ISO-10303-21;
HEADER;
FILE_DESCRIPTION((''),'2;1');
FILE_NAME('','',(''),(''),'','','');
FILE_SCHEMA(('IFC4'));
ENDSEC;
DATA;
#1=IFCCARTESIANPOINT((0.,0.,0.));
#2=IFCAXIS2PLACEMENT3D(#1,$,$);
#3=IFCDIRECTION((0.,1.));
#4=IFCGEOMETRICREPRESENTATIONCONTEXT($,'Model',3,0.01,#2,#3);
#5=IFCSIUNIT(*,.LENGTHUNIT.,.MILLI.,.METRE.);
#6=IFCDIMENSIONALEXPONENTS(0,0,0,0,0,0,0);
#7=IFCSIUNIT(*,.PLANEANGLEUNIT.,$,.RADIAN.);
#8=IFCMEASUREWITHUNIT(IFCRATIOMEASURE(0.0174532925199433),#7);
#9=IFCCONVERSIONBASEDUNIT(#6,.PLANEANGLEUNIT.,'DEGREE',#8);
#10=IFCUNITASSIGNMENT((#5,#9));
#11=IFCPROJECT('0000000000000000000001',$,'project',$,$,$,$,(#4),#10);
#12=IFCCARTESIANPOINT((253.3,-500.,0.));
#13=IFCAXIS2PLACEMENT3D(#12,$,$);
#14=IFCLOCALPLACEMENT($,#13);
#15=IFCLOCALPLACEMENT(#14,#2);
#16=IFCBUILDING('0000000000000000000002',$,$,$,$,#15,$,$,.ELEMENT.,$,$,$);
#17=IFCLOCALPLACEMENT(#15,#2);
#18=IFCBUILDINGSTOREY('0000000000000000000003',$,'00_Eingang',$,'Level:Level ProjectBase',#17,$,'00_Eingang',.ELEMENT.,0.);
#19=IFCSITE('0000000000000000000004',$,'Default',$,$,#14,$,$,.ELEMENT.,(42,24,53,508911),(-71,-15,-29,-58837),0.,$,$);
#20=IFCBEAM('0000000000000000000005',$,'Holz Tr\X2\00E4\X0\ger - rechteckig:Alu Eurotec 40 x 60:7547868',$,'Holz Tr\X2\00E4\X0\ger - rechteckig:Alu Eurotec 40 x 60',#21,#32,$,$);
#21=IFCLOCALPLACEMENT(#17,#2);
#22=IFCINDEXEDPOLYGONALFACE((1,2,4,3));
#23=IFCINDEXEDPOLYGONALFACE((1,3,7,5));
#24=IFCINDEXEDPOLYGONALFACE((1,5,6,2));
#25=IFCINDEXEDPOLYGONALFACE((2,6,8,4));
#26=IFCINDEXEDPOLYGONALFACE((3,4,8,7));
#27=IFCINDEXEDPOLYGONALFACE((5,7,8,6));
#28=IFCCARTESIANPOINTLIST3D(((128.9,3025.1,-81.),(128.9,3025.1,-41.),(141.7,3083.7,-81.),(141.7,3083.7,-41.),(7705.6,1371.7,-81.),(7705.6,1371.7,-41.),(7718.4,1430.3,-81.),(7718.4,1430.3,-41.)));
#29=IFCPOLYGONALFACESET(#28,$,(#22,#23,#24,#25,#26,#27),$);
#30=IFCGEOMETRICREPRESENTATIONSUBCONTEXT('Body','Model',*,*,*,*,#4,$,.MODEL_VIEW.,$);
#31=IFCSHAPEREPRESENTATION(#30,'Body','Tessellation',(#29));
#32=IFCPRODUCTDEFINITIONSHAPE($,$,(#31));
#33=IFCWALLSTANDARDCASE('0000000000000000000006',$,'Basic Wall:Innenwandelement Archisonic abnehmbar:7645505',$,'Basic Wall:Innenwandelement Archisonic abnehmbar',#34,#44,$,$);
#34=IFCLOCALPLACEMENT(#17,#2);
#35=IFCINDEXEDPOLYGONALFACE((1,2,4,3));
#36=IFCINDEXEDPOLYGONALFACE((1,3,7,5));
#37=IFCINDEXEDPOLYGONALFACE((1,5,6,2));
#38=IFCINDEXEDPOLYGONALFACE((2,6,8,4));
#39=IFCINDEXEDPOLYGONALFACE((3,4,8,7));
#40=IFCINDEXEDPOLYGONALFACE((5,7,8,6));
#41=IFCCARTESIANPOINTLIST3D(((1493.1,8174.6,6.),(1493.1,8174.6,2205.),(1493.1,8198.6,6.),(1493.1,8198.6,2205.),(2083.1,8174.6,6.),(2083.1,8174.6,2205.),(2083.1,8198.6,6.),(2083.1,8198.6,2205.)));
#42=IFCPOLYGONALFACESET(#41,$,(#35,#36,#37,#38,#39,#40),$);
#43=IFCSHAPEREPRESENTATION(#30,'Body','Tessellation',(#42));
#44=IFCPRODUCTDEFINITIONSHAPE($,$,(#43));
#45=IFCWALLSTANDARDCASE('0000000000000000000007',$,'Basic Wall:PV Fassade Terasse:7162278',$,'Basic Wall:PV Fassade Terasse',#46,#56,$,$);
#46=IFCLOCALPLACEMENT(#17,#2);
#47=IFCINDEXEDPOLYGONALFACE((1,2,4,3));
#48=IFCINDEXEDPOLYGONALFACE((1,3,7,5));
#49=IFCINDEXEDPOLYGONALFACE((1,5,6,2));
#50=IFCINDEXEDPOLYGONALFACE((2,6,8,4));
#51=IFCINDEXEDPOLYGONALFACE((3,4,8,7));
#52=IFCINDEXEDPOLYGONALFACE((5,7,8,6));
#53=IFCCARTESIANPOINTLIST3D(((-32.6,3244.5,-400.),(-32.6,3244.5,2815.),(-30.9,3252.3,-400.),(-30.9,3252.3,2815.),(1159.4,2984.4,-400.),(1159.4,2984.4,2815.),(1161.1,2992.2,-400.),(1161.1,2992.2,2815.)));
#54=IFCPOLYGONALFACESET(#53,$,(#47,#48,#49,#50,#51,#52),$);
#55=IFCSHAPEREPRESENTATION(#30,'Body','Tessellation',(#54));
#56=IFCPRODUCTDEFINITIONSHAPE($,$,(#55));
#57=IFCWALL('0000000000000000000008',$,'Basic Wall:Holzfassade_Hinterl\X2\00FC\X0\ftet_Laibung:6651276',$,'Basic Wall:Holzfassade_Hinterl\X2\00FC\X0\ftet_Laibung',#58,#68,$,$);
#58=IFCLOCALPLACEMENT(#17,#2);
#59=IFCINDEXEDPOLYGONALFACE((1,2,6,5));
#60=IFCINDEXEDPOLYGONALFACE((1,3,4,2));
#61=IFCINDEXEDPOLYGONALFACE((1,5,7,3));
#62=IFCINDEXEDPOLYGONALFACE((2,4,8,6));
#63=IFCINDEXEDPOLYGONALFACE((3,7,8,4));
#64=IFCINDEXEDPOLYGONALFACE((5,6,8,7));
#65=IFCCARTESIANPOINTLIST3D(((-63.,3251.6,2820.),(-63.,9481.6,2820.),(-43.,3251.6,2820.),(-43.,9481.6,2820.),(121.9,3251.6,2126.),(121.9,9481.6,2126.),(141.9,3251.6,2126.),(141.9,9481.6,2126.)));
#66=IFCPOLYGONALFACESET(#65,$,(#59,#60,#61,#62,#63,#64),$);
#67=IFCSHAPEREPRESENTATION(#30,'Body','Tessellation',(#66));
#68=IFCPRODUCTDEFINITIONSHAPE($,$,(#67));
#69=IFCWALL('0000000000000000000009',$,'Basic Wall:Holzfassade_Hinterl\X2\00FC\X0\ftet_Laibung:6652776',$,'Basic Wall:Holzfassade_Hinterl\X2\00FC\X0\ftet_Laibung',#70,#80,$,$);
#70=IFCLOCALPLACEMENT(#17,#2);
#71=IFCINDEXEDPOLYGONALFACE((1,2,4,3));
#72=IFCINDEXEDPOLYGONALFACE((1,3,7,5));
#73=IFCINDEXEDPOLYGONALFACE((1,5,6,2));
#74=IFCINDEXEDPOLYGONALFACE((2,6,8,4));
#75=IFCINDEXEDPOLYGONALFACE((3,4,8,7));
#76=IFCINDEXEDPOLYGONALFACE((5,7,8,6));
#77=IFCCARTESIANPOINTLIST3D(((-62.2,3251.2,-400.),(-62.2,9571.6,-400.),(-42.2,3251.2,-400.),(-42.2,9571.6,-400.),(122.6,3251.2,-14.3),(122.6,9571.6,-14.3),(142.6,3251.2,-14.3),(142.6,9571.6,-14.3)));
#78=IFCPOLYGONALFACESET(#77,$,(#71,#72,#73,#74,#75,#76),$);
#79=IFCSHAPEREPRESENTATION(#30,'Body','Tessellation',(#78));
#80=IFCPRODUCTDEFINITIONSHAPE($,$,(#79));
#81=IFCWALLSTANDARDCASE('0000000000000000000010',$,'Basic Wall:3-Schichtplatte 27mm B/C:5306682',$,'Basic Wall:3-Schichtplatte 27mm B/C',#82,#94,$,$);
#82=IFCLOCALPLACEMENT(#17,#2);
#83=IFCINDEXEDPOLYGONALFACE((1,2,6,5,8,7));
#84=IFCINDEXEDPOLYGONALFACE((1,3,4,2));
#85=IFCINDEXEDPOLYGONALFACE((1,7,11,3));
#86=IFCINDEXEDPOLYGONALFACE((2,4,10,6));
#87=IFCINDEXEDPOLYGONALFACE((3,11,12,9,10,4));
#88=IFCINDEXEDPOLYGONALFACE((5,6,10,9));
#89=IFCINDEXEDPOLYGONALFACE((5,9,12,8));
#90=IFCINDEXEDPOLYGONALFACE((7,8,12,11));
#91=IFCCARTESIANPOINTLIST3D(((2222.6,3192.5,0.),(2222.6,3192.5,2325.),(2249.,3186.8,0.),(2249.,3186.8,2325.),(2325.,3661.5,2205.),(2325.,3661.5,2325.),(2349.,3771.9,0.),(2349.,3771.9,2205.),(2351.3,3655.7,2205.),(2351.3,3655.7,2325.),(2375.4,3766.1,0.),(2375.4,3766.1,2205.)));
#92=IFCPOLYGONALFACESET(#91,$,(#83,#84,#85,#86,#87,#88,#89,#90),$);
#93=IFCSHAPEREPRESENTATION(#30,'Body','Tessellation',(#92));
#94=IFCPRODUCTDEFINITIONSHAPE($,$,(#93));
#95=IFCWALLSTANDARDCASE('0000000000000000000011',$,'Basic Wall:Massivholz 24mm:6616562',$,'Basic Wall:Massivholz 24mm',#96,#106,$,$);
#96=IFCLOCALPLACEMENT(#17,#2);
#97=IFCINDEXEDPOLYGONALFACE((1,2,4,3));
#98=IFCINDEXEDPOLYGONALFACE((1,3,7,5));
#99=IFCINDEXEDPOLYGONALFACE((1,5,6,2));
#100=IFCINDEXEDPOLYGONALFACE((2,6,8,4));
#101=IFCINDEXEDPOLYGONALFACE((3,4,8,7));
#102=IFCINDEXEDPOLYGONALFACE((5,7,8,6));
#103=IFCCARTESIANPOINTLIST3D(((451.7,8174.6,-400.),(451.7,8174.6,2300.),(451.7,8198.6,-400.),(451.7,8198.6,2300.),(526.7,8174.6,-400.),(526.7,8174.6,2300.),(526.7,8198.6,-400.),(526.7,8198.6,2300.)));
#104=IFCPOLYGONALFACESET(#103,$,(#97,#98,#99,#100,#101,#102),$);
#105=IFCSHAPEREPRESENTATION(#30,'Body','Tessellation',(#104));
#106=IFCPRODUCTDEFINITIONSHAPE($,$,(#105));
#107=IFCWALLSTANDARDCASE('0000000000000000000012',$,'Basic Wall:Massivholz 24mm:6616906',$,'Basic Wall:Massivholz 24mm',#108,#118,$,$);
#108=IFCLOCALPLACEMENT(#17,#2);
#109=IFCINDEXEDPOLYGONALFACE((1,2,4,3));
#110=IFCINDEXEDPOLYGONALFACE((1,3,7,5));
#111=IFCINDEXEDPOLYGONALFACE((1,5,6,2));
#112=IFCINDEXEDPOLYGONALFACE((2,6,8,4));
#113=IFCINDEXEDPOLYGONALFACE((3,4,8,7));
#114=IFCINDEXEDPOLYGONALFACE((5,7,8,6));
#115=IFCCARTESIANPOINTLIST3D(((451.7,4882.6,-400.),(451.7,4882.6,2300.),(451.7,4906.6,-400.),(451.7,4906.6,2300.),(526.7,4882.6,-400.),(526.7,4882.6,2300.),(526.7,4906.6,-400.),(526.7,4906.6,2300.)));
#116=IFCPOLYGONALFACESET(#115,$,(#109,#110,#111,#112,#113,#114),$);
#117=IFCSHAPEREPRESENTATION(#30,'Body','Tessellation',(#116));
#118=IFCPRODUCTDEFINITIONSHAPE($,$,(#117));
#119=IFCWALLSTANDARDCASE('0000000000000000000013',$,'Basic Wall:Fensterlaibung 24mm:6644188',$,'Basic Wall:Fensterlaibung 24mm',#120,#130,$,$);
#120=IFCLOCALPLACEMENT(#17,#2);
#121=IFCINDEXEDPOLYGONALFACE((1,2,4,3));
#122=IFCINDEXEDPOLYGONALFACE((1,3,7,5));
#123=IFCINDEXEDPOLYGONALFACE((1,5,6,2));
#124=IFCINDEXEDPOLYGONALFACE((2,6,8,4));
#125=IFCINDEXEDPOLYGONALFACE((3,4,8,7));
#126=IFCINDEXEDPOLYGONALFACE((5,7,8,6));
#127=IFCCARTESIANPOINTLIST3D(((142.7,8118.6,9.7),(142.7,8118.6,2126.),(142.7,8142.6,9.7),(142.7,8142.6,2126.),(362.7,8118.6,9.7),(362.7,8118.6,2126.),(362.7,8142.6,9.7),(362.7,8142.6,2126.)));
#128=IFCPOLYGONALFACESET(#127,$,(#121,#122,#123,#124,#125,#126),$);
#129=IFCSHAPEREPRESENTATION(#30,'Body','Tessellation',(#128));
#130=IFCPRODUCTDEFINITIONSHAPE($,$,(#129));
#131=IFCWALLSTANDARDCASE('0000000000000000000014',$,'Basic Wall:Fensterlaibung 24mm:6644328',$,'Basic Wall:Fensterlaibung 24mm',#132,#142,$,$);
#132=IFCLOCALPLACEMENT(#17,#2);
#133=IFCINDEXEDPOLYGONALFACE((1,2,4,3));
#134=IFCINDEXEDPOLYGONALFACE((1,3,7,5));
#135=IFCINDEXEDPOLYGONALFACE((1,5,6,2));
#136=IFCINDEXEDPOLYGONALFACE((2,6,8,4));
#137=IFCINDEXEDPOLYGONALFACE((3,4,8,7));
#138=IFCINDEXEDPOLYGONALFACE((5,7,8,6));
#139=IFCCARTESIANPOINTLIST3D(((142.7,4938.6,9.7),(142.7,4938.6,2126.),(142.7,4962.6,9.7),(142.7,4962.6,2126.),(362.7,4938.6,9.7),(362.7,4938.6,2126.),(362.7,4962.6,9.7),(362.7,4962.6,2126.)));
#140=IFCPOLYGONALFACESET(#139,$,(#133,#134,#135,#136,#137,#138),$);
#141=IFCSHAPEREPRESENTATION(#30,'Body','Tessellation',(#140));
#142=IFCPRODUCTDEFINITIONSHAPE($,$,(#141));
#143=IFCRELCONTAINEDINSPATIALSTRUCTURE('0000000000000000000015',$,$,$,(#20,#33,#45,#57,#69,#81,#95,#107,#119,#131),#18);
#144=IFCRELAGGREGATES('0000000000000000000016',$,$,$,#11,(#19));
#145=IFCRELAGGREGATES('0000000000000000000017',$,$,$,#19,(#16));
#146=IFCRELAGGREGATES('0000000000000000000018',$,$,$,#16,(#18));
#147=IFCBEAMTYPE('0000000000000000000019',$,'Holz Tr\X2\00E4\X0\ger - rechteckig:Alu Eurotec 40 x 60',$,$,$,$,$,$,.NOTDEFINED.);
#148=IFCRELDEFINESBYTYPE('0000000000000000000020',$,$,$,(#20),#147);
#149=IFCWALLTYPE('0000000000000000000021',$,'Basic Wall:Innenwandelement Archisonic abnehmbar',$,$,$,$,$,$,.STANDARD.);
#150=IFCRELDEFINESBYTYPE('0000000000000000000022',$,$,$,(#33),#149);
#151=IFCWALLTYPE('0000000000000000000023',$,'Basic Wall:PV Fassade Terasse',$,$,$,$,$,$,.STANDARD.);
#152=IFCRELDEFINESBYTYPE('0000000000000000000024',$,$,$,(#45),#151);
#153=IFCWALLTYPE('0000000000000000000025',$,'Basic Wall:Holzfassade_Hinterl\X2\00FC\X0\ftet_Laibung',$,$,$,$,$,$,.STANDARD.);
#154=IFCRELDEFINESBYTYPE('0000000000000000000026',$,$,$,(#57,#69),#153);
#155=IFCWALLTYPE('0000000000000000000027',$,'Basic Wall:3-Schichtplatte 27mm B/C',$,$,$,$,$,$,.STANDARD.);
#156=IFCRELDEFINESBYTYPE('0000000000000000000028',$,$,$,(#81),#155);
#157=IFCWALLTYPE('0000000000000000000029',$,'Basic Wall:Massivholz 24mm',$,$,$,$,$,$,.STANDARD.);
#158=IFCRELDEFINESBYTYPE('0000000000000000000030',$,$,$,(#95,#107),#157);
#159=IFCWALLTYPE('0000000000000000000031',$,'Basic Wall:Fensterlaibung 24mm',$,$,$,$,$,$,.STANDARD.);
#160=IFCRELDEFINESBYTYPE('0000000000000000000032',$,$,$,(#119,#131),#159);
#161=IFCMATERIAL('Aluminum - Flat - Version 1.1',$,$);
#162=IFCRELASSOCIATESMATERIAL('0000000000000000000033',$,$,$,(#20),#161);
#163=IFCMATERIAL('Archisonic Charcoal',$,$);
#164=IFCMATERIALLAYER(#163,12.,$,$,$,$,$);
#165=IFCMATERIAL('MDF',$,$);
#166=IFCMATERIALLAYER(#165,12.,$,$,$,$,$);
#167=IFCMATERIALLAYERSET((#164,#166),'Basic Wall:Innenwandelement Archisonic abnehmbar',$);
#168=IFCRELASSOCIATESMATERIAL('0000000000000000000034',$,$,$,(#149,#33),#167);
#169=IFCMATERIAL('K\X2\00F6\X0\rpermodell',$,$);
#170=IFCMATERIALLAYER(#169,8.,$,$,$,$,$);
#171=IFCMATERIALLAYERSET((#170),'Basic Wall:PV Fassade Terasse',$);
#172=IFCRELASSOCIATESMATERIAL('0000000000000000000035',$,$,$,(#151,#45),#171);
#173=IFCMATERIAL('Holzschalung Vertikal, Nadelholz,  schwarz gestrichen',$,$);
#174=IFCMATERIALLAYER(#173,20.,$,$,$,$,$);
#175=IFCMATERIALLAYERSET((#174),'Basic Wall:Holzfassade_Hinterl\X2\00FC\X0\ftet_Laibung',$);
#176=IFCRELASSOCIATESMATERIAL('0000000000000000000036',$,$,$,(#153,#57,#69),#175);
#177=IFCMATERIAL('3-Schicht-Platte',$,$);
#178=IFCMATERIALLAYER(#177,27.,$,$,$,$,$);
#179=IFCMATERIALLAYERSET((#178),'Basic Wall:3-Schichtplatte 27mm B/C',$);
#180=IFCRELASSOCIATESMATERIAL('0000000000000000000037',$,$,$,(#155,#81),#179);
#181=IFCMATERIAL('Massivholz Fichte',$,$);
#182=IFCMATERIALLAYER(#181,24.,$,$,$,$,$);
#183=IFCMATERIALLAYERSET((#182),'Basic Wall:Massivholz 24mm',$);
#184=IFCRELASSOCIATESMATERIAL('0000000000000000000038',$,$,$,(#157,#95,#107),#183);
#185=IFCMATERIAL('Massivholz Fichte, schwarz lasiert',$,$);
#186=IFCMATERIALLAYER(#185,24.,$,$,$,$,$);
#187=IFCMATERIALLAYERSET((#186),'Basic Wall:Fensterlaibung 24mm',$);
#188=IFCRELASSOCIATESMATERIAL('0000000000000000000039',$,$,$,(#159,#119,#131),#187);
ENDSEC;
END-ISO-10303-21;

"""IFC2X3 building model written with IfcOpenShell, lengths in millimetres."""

from ifc_helpers import new_model, entity, si_unit, converted_unit, direction, frame, frame_2d, origin, place, context, subcontext, project, spatial, polyline, rectangle, extrude, clip, bounded_halfspace, material, layer, layer_set, layer_usage, type_object, element, save


model = new_model("IFC2X3")

# Units and contexts
model_context = context("Model", 3, precision=0.01, world=origin(), true_north=direction((0.0, 1.0)))
body_context = subcontext(model_context, "Body", "Model", "MODEL_VIEW")
ifc_project = project(units=[si_unit("LENGTHUNIT", "METRE", prefix="MILLI"), converted_unit("PLANEANGLEUNIT", "DEGREE", entity("IfcRatioMeasure", 0.0174532925199433), si_unit("PLANEANGLEUNIT", "RADIAN"), dimensions=[0, 0, 0, 0, 0, 0, 0])], contexts=[model_context])

# Site, building, storey
site_placement = place(None, frame((253.3, -500.0, 0.0)))
site = spatial("IfcSite", under=ifc_project, at=site_placement, Name="Default", CompositionType="ELEMENT", RefLatitude=(42, 24, 53, 508911), RefLongitude=(-71, -15, -29, -58837), RefElevation=0.0)
building_placement = place(site_placement, origin())
building = spatial("IfcBuilding", under=site, at=building_placement, CompositionType="ELEMENT")
storey_placement = place(building_placement, origin())
storey = spatial("IfcBuildingStorey", under=building, at=storey_placement, Name="00_Eingang", ObjectType="Level:Level ProjectBase", LongName="00_Eingang", CompositionType="ELEMENT", Elevation=0.0)

# Beam
ifc_material_1 = material(Name="Aluminum - Flat - Version 1.1")
beam_type = type_object("IfcBeamType", Name="Holz Träger - rechteckig:Alu Eurotec 40 x 60", PredefinedType="NOTDEFINED")
beam_placement = place(storey_placement, frame((135.3, 3054.4, -41.0), z_axis=(0.0, 0.0, 1.0), x_axis=(0.977008, -0.213201, 0.0)))
element("IfcBeam", 1, at=beam_placement, inside=storey, type_object=beam_type, material=ifc_material_1, Name="Holz Träger - rechteckig:Alu Eurotec 40 x 60:7547868", ObjectType="Holz Träger - rechteckig:Alu Eurotec 40 x 60", context=body_context, shape_type="SweptSolid", body=[
    extrude(rectangle(XDim=40.0, YDim=60.0, at=frame_2d((0.0, 0.0), x_axis=(1.0, 0.0))), frame((0.0, 0.0, -20.0), z_axis=(1.0, 0.0, 0.0), x_axis=(0.0, 0.0, -1.0)), (0.0, 0.0, 1.0), 7755.0),
])

# Shared definitions
ifc_material_2 = material(Name="3-Schicht-Platte")

# Walls
ifc_material_3 = material(Name="Archisonic Charcoal")
ifc_layer_1 = layer(ifc_material_3, 12.0)
ifc_material_4 = material(Name="MDF")
ifc_layer_2 = layer(ifc_material_4, 12.0)
ifc_layer_set_1 = layer_set([ifc_layer_1, ifc_layer_2], Name="Basic Wall:Innenwandelement Archisonic abnehmbar")
ifc_layer_usage_1 = layer_usage(ifc_layer_set_1, "AXIS2", "NEGATIVE", 12.0)
wall_type_1 = type_object("IfcWallType", Name="Basic Wall:Innenwandelement Archisonic abnehmbar", PredefinedType="STANDARD", material=ifc_layer_set_1)
wall_1_placement = place(storey_placement, frame((2083.1, 8186.6, 6.0), z_axis=(0.0, 0.0, 1.0), x_axis=(-1.0, 0.0, 0.0)))
element("IfcWallStandardCase", 2, at=wall_1_placement, inside=storey, type_object=wall_type_1, material=ifc_layer_usage_1, Name="Basic Wall:Innenwandelement Archisonic abnehmbar:7645505", ObjectType="Basic Wall:Innenwandelement Archisonic abnehmbar", context=body_context, shape_type="SweptSolid", body=[
    extrude(rectangle(XDim=590.0, YDim=24.0, at=frame_2d((295.0, 0.0), x_axis=(-1.0, 0.0))), origin(), (0.0, 0.0, 1.0), 2199.0),
])
ifc_material_5 = material(Name="Körpermodell")
ifc_layer_3 = layer(ifc_material_5, 8.0)
ifc_layer_set_2 = layer_set([ifc_layer_3], Name="Basic Wall:PV Fassade Terasse")
ifc_layer_usage_2 = layer_usage(ifc_layer_set_2, "AXIS2", "NEGATIVE", 4.0)
wall_type_2 = type_object("IfcWallType", Name="Basic Wall:PV Fassade Terasse", PredefinedType="STANDARD", material=ifc_layer_set_2)
wall_2_placement = place(storey_placement, frame((1160.2, 2988.3, -400.0), z_axis=(0.0, 0.0, 1.0), x_axis=(-0.977008, 0.213201, 0.0)))
element("IfcWallStandardCase", 3, at=wall_2_placement, inside=storey, type_object=wall_type_2, material=ifc_layer_usage_2, Name="Basic Wall:PV Fassade Terasse:7162278", ObjectType="Basic Wall:PV Fassade Terasse", context=body_context, shape_type="SweptSolid", body=[
    extrude(rectangle(XDim=1220.0, YDim=8.0, at=frame_2d((610.0, 0.0), x_axis=(-1.0, 0.0))), origin(), (0.0, 0.0, 1.0), 3215.0),
])

# Walls
ifc_material_6 = material(Name="Holzschalung Vertikal, Nadelholz,  schwarz gestrichen")
ifc_layer_4 = layer(ifc_material_6, 20.0)
ifc_layer_set_3 = layer_set([ifc_layer_4], Name="Basic Wall:Holzfassade_Hinterlüftet_Laibung")
wall_type_3 = type_object("IfcWallType", Name="Basic Wall:Holzfassade_Hinterlüftet_Laibung", PredefinedType="STANDARD", material=ifc_layer_set_3)
wall_3_placement = place(storey_placement, frame((131.9, 3251.6, 2126.0), z_axis=(0.0, 0.0, 1.0), x_axis=(0.0, 1.0, 0.0)))
element("IfcWall", 4, at=wall_3_placement, inside=storey, type_object=wall_type_3, material=ifc_layer_set_3, Name="Basic Wall:Holzfassade_Hinterlüftet_Laibung:6651276", ObjectType="Basic Wall:Holzfassade_Hinterlüftet_Laibung", context=body_context, shape_type="SweptSolid", body=[
    extrude(rectangle(XDim=6230.0, YDim=20.0, at=frame_2d((3115.0, 0.0), x_axis=(-1.0, 0.0))), origin(), (0.0, 0.25747, 0.966286), 718.2),
])
wall_4_placement = place(storey_placement, frame((-52.2, 3251.2, -400.0), z_axis=(0.0, 0.0, 1.0), x_axis=(0.0, 1.0, 0.0)))
element("IfcWall", 5, at=wall_4_placement, inside=storey, type_object=wall_type_3, material=ifc_layer_set_3, Name="Basic Wall:Holzfassade_Hinterlüftet_Laibung:6652776", ObjectType="Basic Wall:Holzfassade_Hinterlüftet_Laibung", context=body_context, shape_type="SweptSolid", body=[
    extrude(rectangle(XDim=6320.5, YDim=20.0, at=frame_2d((3160.2, 0.0), x_axis=(-1.0, 0.0))), origin(), (0.0, -0.432243, 0.901757), 427.7),
])

# Shared definitions
ifc_layer_5 = layer(ifc_material_2, 27.0)
ifc_layer_set_4 = layer_set([ifc_layer_5], Name="Basic Wall:3-Schichtplatte 27mm B/C")
wall_type_4 = type_object("IfcWallType", Name="Basic Wall:3-Schichtplatte 27mm B/C", PredefinedType="STANDARD", material=ifc_layer_set_4)

# Walls
ifc_layer_usage_3 = layer_usage(ifc_layer_set_4, "AXIS2", "NEGATIVE", 13.5)
wall_5_placement = place(storey_placement, frame((2362.2, 3769.0, 0.0), z_axis=(0.0, 0.0, 1.0), x_axis=(-0.213201, -0.977008, 0.0)))
element("IfcWallStandardCase", 6, at=wall_5_placement, inside=storey, type_object=wall_type_4, material=ifc_layer_usage_3, Name="Basic Wall:3-Schichtplatte 27mm B/C:5306682", ObjectType="Basic Wall:3-Schichtplatte 27mm B/C", context=body_context, shape_type="Clipping", body=[
    clip(clip(clip(extrude(rectangle(XDim=593.0, YDim=27.0, at=frame_2d((296.5, 0.0), x_axis=(-1.0, 0.0))), origin(), (0.0, 0.0, 1.0), 2325.0), bounded_halfspace(frame((113.0, -13.5, 2325.0), z_axis=(0.0, 0.0, -1.0), x_axis=(-0.213201, 0.977008, 0.0)), True, frame((113.0, -13.5, 2325.0)), polyline([(0.0, 0.0), (480.0, 0.0), (480.0, 27.0), (0.0, 27.0), (0.0, 0.0)]))), bounded_halfspace(frame((113.0, 13.5, 2205.0), z_axis=(1.0, 0.0, 0.0), x_axis=(0.0, 1.0, 0.0)), True, frame((113.0, 13.5, 2205.0), z_axis=(1.0, 0.0, 0.0), x_axis=(0.0, 1.0, 0.0)), polyline([(0.0, 0.0), (0.0, 120.0), (-27.0, 120.0), (-27.0, 0.0), (0.0, 0.0)]))), bounded_halfspace(frame((113.0, -13.5, 2205.0), z_axis=(0.0, 0.0, -1.0), x_axis=(0.0, 1.0, 0.0)), True, frame((113.0, -13.5, 2205.0), z_axis=(0.0, 0.0, -1.0), x_axis=(0.0, 1.0, 0.0)), polyline([(0.0, 0.0), (0.0, -113.0), (27.0, -113.0), (27.0, 0.0), (0.0, 0.0)]))),
])
ifc_material_7 = material(Name="Massivholz Fichte")
ifc_layer_6 = layer(ifc_material_7, 24.0)
ifc_layer_set_5 = layer_set([ifc_layer_6], Name="Basic Wall:Massivholz 24mm")
ifc_layer_usage_4 = layer_usage(ifc_layer_set_5, "AXIS2", "POSITIVE", -12.0)
wall_type_5 = type_object("IfcWallType", Name="Basic Wall:Massivholz 24mm", PredefinedType="STANDARD", material=ifc_layer_set_5)
wall_6_placement = place(storey_placement, frame((526.7, 8186.6, -400.0), z_axis=(0.0, 0.0, 1.0), x_axis=(-1.0, 0.0, 0.0)))
element("IfcWallStandardCase", 7, at=wall_6_placement, inside=storey, type_object=wall_type_5, material=ifc_layer_usage_4, Name="Basic Wall:Massivholz 24mm:6616562", ObjectType="Basic Wall:Massivholz 24mm", context=body_context, shape_type="SweptSolid", body=[
    extrude(rectangle(XDim=75.0, YDim=24.0, at=frame_2d((37.5, 0.0), x_axis=(-1.0, 0.0))), origin(), (0.0, 0.0, 1.0), 2700.0),
])
ifc_layer_usage_5 = layer_usage(ifc_layer_set_5, "AXIS2", "NEGATIVE", 12.0)
wall_7_placement = place(storey_placement, frame((526.7, 4894.6, -400.0), z_axis=(0.0, 0.0, 1.0), x_axis=(-1.0, 0.0, 0.0)))
element("IfcWallStandardCase", 8, at=wall_7_placement, inside=storey, type_object=wall_type_5, material=ifc_layer_usage_5, Name="Basic Wall:Massivholz 24mm:6616906", ObjectType="Basic Wall:Massivholz 24mm", context=body_context, shape_type="SweptSolid", body=[
    extrude(rectangle(XDim=75.0, YDim=24.0, at=frame_2d((37.5, 0.0), x_axis=(-1.0, 0.0))), origin(), (0.0, 0.0, 1.0), 2700.0),
])
ifc_material_8 = material(Name="Massivholz Fichte, schwarz lasiert")
ifc_layer_7 = layer(ifc_material_8, 24.0)
ifc_layer_set_6 = layer_set([ifc_layer_7], Name="Basic Wall:Fensterlaibung 24mm")
ifc_layer_usage_6 = layer_usage(ifc_layer_set_6, "AXIS2", "POSITIVE", -12.0)
wall_type_6 = type_object("IfcWallType", Name="Basic Wall:Fensterlaibung 24mm", PredefinedType="STANDARD", material=ifc_layer_set_6)
wall_8_placement = place(storey_placement, frame((362.7, 8130.6, 9.7), z_axis=(0.0, 0.0, 1.0), x_axis=(-1.0, 0.0, 0.0)))
element("IfcWallStandardCase", 9, at=wall_8_placement, inside=storey, type_object=wall_type_6, material=ifc_layer_usage_6, Name="Basic Wall:Fensterlaibung 24mm:6644188", ObjectType="Basic Wall:Fensterlaibung 24mm", context=body_context, shape_type="Clipping", body=[
    clip(clip(extrude(rectangle(XDim=220.0, YDim=24.0, at=frame_2d((110.0, 0.0), x_axis=(-1.0, 0.0))), origin(), (0.0, 0.0, 1.0), 2116.3), bounded_halfspace(frame((220.0, -12.0, 0.0)), True, frame((220.0, -12.0, 0.0)), polyline([(0.0, 0.0), (0.0, 24.0), (-220.0, 24.0), (-220.0, 0.0), (0.0, 0.0)]))), bounded_halfspace(frame((0.0, -12.0, 2116.3), z_axis=(0.0, 0.0, -1.0), x_axis=(-1.0, 0.0, 0.0)), True, frame((0.0, -12.0, 2116.3)), polyline([(0.0, 0.0), (215.0, 0.0), (215.0, 24.0), (0.0, 24.0), (0.0, 0.0)]))),
])
ifc_layer_usage_7 = layer_usage(ifc_layer_set_6, "AXIS2", "NEGATIVE", 12.0)
wall_9_placement = place(storey_placement, frame((362.7, 4950.6, 9.7), z_axis=(0.0, 0.0, 1.0), x_axis=(-1.0, 0.0, 0.0)))
element("IfcWallStandardCase", 10, at=wall_9_placement, inside=storey, type_object=wall_type_6, material=ifc_layer_usage_7, Name="Basic Wall:Fensterlaibung 24mm:6644328", ObjectType="Basic Wall:Fensterlaibung 24mm", context=body_context, shape_type="Clipping", body=[
    clip(clip(extrude(rectangle(XDim=220.0, YDim=24.0, at=frame_2d((110.0, 0.0), x_axis=(-1.0, 0.0))), origin(), (0.0, 0.0, 1.0), 2116.3), bounded_halfspace(frame((220.0, -12.0, 0.0)), True, frame((220.0, -12.0, 0.0)), polyline([(0.0, 0.0), (0.0, 24.0), (-220.0, 24.0), (-220.0, 0.0), (0.0, 0.0)]))), bounded_halfspace(frame((0.0, -12.0, 2116.3), z_axis=(0.0, 0.0, -1.0), x_axis=(-1.0, 0.0, 0.0)), True, frame((0.0, -12.0, 2116.3)), polyline([(0.0, 0.0), (215.0, 0.0), (215.0, 24.0), (0.0, 24.0), (0.0, 0.0)]))),
])

save(model, "model.ifc")
